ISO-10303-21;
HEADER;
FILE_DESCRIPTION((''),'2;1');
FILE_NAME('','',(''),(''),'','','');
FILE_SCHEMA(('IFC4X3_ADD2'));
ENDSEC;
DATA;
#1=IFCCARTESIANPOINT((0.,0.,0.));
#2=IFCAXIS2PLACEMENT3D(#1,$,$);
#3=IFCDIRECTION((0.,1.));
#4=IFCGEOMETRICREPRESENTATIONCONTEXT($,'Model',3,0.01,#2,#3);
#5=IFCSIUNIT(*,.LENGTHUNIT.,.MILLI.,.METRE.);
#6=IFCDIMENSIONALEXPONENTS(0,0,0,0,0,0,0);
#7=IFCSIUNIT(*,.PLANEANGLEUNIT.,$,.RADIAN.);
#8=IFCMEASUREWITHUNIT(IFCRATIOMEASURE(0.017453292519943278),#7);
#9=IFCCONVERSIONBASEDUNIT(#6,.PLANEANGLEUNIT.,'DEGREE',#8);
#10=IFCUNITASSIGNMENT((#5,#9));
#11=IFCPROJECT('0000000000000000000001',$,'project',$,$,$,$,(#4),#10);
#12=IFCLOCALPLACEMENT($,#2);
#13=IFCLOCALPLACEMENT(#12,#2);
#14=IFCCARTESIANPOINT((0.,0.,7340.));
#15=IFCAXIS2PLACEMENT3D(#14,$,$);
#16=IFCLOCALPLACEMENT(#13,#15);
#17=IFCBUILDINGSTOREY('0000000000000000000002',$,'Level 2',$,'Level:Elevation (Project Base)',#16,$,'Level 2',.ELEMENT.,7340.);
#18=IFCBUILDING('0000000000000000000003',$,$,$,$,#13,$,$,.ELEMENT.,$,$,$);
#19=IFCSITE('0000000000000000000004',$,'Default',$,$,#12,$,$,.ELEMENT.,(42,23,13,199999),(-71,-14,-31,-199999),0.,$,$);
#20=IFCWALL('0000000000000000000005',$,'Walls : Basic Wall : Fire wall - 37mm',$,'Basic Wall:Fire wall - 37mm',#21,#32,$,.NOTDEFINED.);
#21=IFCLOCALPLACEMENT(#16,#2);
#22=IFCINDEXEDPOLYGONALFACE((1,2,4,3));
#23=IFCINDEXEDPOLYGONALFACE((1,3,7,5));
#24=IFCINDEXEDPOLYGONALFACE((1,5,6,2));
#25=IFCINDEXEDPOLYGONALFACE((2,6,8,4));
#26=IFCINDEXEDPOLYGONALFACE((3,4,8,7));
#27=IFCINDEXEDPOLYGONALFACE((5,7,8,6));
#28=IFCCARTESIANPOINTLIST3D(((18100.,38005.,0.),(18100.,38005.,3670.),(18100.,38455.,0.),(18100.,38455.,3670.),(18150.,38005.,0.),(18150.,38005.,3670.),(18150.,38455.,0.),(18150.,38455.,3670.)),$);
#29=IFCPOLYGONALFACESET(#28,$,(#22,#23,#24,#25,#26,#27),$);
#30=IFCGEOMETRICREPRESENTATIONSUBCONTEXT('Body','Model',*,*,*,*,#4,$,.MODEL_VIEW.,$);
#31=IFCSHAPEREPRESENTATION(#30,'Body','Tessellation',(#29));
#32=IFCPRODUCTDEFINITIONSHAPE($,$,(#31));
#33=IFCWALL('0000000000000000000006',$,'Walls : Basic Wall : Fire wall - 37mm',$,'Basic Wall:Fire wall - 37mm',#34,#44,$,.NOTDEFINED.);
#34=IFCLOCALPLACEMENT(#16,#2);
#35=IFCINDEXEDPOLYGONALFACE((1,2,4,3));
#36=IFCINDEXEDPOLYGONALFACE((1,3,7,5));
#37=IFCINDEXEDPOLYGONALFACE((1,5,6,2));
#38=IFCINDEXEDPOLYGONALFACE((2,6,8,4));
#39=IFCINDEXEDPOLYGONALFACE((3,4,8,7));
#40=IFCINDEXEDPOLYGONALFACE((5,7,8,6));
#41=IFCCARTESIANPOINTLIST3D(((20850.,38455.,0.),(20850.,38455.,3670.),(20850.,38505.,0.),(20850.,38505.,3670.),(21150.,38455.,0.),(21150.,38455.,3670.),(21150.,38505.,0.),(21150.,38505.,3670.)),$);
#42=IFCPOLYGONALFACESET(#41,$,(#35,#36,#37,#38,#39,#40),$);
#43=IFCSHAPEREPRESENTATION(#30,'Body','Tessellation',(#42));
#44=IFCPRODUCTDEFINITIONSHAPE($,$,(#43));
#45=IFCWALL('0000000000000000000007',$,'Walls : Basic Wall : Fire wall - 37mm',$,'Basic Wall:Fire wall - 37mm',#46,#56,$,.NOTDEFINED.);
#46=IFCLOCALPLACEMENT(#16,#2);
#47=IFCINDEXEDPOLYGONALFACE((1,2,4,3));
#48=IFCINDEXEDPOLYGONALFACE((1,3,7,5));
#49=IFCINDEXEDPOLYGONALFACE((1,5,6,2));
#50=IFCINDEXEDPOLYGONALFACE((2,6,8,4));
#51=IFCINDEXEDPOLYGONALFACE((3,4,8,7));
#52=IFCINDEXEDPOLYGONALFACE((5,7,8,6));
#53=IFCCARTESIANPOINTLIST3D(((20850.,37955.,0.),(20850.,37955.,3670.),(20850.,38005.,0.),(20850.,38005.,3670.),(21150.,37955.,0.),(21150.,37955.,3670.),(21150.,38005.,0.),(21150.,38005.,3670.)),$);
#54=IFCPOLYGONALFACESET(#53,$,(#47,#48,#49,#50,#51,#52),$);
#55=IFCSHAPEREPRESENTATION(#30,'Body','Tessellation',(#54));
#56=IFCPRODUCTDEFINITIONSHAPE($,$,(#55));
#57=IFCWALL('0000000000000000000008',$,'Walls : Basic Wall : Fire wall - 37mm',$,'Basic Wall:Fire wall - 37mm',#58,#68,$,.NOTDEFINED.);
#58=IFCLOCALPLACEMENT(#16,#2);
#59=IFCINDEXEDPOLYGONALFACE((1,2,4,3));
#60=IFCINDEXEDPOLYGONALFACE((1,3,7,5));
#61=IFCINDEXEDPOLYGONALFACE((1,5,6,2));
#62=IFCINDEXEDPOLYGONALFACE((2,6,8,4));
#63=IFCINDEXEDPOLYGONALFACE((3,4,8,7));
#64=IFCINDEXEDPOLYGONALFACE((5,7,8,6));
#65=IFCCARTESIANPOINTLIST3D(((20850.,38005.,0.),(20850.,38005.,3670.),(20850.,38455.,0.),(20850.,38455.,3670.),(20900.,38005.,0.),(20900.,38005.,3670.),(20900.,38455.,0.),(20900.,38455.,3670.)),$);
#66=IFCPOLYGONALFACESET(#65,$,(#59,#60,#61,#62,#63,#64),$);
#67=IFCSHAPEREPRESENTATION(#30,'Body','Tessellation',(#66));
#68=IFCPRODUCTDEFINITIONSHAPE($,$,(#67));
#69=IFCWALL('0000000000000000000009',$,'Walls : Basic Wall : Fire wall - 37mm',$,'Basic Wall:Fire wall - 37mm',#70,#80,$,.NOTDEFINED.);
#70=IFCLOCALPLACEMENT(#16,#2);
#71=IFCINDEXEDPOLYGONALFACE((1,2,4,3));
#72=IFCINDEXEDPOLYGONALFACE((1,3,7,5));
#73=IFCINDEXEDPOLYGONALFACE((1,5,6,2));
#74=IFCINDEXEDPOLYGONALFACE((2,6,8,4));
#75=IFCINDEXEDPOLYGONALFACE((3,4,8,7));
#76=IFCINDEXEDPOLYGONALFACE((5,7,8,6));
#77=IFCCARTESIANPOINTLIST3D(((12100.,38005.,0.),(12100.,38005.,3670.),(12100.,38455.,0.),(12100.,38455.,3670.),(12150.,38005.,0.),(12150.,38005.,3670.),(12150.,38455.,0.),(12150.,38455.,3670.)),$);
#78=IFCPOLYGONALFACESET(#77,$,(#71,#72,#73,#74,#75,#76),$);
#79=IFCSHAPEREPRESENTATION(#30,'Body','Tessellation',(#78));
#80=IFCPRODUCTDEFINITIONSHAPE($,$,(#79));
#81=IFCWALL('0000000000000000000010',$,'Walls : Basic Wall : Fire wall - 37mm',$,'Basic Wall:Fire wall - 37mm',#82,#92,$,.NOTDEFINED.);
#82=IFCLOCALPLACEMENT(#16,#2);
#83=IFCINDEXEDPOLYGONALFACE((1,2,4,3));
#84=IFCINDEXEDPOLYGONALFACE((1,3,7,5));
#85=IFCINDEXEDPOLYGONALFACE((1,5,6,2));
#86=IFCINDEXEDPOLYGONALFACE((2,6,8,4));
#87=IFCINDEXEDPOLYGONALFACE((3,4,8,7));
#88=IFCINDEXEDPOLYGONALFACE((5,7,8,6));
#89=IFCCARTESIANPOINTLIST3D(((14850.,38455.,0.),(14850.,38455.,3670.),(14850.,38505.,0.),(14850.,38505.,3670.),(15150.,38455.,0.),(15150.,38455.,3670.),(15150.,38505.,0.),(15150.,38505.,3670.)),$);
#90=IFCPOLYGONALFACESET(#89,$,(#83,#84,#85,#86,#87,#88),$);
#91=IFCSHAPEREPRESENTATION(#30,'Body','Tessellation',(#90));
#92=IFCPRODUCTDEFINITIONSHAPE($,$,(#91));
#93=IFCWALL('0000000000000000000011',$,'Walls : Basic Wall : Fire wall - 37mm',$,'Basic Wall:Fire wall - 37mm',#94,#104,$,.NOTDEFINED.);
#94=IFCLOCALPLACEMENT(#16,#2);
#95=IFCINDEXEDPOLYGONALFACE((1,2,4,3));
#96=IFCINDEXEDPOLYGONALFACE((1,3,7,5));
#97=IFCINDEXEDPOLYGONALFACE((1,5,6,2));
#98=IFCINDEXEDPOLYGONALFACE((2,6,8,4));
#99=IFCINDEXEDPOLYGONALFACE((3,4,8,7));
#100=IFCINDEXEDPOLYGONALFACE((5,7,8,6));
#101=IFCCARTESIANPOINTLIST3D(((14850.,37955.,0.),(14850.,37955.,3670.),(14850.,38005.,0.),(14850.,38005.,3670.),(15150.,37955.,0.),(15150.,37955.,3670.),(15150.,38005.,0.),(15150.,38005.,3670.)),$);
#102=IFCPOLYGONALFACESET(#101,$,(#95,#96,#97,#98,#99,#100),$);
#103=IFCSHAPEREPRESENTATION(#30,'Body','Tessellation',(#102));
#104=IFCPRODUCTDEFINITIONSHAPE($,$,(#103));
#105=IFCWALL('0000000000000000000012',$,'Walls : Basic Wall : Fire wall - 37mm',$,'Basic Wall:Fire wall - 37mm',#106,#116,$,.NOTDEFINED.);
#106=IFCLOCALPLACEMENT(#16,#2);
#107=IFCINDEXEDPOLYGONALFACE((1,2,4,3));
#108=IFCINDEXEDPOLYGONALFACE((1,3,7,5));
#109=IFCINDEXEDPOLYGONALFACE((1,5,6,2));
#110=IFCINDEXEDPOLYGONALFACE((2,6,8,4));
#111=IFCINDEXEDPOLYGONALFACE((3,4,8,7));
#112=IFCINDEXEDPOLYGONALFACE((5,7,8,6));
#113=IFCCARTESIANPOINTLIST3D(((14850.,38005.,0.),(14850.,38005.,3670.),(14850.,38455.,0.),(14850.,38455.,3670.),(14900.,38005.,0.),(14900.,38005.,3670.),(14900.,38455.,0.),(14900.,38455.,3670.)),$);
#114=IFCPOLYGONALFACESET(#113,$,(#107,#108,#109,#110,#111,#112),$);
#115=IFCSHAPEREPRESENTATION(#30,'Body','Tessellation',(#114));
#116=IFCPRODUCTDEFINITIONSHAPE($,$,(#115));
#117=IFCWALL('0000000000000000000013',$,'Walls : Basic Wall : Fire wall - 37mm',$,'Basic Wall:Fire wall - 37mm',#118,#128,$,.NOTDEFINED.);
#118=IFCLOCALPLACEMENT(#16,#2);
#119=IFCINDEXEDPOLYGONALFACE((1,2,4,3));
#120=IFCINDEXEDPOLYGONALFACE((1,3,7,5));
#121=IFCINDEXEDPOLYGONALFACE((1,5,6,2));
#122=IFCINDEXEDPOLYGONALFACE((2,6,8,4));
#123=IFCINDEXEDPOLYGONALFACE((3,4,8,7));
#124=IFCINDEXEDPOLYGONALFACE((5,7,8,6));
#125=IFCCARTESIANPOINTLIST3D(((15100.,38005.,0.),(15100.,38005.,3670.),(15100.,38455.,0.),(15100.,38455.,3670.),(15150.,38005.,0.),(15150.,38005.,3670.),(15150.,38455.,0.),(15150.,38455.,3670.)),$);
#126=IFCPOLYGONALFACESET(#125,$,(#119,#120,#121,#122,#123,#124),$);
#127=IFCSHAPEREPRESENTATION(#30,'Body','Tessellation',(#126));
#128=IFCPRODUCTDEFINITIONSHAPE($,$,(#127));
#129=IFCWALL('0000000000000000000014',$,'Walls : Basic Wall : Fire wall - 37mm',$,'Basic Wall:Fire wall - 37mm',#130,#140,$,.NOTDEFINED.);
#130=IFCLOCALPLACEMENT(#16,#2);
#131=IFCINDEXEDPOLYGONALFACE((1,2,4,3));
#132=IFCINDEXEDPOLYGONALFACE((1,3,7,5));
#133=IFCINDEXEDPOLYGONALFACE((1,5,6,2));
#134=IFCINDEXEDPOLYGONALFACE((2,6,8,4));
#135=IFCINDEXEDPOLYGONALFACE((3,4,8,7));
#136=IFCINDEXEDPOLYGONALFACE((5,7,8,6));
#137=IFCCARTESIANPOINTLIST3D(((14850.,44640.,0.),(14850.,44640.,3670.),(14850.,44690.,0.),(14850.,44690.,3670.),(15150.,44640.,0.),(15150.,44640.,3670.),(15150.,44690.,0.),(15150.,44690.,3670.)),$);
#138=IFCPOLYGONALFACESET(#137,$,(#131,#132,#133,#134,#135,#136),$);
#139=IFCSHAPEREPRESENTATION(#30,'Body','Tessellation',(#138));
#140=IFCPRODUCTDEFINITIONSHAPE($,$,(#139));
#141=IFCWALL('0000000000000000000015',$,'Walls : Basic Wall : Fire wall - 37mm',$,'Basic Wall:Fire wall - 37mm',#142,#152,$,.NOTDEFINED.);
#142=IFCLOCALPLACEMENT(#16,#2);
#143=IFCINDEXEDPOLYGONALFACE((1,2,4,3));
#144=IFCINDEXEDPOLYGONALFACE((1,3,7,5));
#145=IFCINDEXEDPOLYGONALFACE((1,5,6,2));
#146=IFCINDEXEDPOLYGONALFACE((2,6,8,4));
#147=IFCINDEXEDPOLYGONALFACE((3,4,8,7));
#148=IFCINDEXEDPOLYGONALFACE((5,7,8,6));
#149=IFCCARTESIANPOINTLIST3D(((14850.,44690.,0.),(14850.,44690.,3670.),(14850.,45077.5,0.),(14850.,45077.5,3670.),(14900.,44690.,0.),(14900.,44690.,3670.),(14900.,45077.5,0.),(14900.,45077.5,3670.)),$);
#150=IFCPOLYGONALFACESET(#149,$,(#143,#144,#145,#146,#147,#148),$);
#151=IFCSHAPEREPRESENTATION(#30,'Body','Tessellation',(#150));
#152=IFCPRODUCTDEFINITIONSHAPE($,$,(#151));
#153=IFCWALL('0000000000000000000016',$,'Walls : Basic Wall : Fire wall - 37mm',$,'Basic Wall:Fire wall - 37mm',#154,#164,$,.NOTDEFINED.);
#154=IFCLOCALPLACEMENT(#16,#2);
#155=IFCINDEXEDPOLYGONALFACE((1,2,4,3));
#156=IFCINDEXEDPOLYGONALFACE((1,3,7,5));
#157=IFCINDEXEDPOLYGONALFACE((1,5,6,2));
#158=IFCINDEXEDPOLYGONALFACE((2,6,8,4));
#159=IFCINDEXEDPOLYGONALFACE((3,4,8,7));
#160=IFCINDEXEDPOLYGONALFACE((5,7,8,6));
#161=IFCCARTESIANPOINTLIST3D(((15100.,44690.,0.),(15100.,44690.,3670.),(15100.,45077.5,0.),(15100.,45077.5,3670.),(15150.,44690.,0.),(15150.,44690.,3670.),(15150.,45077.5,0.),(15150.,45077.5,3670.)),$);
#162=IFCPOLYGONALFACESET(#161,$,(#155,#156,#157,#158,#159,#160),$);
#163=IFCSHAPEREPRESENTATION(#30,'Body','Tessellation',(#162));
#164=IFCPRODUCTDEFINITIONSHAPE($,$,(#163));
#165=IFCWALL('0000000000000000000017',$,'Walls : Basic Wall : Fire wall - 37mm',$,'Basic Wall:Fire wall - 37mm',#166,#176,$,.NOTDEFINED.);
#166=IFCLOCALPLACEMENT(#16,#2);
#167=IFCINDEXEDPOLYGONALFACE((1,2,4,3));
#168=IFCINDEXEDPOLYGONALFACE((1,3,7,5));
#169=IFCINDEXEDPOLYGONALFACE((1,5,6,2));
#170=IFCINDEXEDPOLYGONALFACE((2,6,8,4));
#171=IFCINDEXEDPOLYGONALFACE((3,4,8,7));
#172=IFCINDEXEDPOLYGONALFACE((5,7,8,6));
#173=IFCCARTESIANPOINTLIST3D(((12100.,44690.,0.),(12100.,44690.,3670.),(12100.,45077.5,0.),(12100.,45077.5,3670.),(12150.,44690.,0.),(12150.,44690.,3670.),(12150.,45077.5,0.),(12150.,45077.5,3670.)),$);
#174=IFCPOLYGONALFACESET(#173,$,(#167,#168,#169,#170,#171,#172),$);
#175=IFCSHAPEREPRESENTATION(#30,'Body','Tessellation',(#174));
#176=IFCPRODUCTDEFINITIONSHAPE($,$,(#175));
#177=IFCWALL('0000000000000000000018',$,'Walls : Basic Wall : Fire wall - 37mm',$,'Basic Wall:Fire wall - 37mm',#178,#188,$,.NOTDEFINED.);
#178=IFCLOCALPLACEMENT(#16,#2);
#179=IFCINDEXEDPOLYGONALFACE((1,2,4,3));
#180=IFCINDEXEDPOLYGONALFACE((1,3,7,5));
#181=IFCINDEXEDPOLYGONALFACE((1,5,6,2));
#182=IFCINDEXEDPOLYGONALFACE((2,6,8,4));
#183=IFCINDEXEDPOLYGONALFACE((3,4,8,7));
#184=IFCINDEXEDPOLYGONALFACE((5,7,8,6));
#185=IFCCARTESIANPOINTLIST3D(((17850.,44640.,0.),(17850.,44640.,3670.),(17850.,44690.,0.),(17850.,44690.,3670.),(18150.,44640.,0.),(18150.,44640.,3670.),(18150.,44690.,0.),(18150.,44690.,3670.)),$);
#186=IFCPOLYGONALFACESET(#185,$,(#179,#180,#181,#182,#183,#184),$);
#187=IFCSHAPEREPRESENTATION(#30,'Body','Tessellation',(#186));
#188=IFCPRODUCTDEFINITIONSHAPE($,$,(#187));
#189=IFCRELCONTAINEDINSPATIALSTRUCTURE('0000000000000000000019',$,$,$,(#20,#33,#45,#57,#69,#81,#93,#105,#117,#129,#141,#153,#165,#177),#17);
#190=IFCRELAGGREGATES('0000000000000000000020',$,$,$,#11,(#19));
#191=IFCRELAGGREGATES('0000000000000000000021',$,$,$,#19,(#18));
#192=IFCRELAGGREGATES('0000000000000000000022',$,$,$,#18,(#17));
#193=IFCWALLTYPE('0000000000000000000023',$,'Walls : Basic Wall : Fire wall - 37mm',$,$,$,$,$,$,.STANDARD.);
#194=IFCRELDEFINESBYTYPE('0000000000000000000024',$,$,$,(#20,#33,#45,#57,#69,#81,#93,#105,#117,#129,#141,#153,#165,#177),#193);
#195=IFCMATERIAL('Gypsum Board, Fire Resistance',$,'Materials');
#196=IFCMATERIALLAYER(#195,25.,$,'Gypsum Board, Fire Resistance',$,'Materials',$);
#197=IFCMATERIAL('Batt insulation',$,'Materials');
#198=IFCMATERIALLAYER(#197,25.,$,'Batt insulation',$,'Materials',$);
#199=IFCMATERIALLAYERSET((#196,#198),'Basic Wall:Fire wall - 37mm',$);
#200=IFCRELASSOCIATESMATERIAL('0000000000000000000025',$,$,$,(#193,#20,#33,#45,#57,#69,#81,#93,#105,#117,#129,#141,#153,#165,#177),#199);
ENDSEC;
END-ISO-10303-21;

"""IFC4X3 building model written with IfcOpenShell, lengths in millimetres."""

from ifc_helpers import new_model, entity, si_unit, converted_unit, direction, frame, frame_2d, origin, place, context, subcontext, project, spatial, rectangle, extrude, material, layer, layer_set, type_object, element, save


model = new_model("IFC4X3")

# Units and contexts
model_context = context("Model", 3, precision=0.01, world=origin(), true_north=direction((0.0, 1.0)))
body_context = subcontext(model_context, "Body", "Model", "MODEL_VIEW")
ifc_project = project(units=[si_unit("LENGTHUNIT", "METRE", prefix="MILLI"), converted_unit("PLANEANGLEUNIT", "DEGREE", entity("IfcRatioMeasure", 0.017453292519943278), si_unit("PLANEANGLEUNIT", "RADIAN"), dimensions=[0, 0, 0, 0, 0, 0, 0])], contexts=[model_context])

# Site, building, storey
site_placement = place(None, origin())
site = spatial("IfcSite", under=ifc_project, at=site_placement, Name="Default", CompositionType="ELEMENT", RefLatitude=(42, 23, 13, 199999), RefLongitude=(-71, -14, -31, -199999), RefElevation=0.0)
building_placement = place(site_placement, origin())
building = spatial("IfcBuilding", under=site, at=building_placement, CompositionType="ELEMENT")
storey_placement = place(building_placement, frame((0.0, 0.0, 7340.0)))
storey = spatial("IfcBuildingStorey", under=building, at=storey_placement, Name="Level 2", ObjectType="Level:Elevation (Project Base)", LongName="Level 2", CompositionType="ELEMENT", Elevation=7340.0)

# Walls
ifc_material_1 = material(Name="Gypsum Board, Fire Resistance", Category="Materials")
ifc_layer_1 = layer(ifc_material_1, 25.0, Name="Gypsum Board, Fire Resistance", Category="Materials")
ifc_material_2 = material(Name="Batt insulation", Category="Materials")
ifc_layer_2 = layer(ifc_material_2, 25.0, Name="Batt insulation", Category="Materials")
ifc_layer_set = layer_set([ifc_layer_1, ifc_layer_2], Name="Basic Wall:Fire wall - 37mm")
wall_type = type_object("IfcWallType", Name="Walls : Basic Wall : Fire wall - 37mm", PredefinedType="STANDARD", material=ifc_layer_set)
for number, where, z_axis, x_axis, name in (
    (1, (18125.0, 38455.0, 0.0), (0.0, 0.0, 1.0), (0.0, -1.0, 0.0), "Walls : Basic Wall : Fire wall - 37mm"),
):
    element("IfcWall", number, at=place(storey_placement, frame(where, z_axis=z_axis, x_axis=x_axis)), inside=storey, type_object=wall_type, material=ifc_layer_set, Name=name, ObjectType="Basic Wall:Fire wall - 37mm", PredefinedType="NOTDEFINED", context=body_context, shape_type="SweptSolid", body=[
        extrude(rectangle(XDim=450.0, YDim=50.0, at=frame_2d((225.0, 0.0), x_axis=(-1.0, 0.0))), origin(), (0.0, 0.0, 1.0), 3670.0),
    ])
for number, where, name in (
    (2, (20850.0, 38480.0, 0.0), "Walls : Basic Wall : Fire wall - 37mm"),
    (3, (20850.0, 37980.0, 0.0), "Walls : Basic Wall : Fire wall - 37mm"),
):
    element("IfcWall", number, at=place(storey_placement, frame(where)), inside=storey, type_object=wall_type, material=ifc_layer_set, Name=name, ObjectType="Basic Wall:Fire wall - 37mm", PredefinedType="NOTDEFINED", context=body_context, shape_type="SweptSolid", body=[
        extrude(rectangle(XDim=300.0, YDim=50.0, at=frame_2d((150.0, 0.0), x_axis=(-1.0, 0.0))), origin(), (0.0, 0.0, 1.0), 3670.0),
    ])
wall_1_placement = place(storey_placement, frame((20875.0, 38455.0, 0.0), z_axis=(0.0, 0.0, 1.0), x_axis=(0.0, -1.0, 0.0)))
element("IfcWall", 4, at=wall_1_placement, inside=storey, type_object=wall_type, material=ifc_layer_set, Name="Walls : Basic Wall : Fire wall - 37mm", ObjectType="Basic Wall:Fire wall - 37mm", PredefinedType="NOTDEFINED", context=body_context, shape_type="SweptSolid", body=[
    extrude(rectangle(XDim=450.0, YDim=50.0, at=frame_2d((225.0, 0.0), x_axis=(-1.0, 0.0))), origin(), (0.0, 0.0, 1.0), 3670.0),
])
wall_2_placement = place(storey_placement, frame((12125.0, 38455.0, 0.0), z_axis=(0.0, 0.0, 1.0), x_axis=(0.0, -1.0, 0.0)))
element("IfcWall", 5, at=wall_2_placement, inside=storey, type_object=wall_type, material=ifc_layer_set, Name="Walls : Basic Wall : Fire wall - 37mm", ObjectType="Basic Wall:Fire wall - 37mm", PredefinedType="NOTDEFINED", context=body_context, shape_type="SweptSolid", body=[
    extrude(rectangle(XDim=450.0, YDim=50.0, at=frame_2d((225.0, 0.0), x_axis=(-1.0, 0.0))), origin(), (0.0, 0.0, 1.0), 3670.0),
])
for number, where, name in (
    (6, (14850.0, 38480.0, 0.0), "Walls : Basic Wall : Fire wall - 37mm"),
    (7, (14850.0, 37980.0, 0.0), "Walls : Basic Wall : Fire wall - 37mm"),
):
    element("IfcWall", number, at=place(storey_placement, frame(where)), inside=storey, type_object=wall_type, material=ifc_layer_set, Name=name, ObjectType="Basic Wall:Fire wall - 37mm", PredefinedType="NOTDEFINED", context=body_context, shape_type="SweptSolid", body=[
        extrude(rectangle(XDim=300.0, YDim=50.0, at=frame_2d((150.0, 0.0), x_axis=(-1.0, 0.0))), origin(), (0.0, 0.0, 1.0), 3670.0),
    ])
for number, where, z_axis, x_axis, name in (
    (8, (14875.0, 38455.0, 0.0), (0.0, 0.0, 1.0), (0.0, -1.0, 0.0), "Walls : Basic Wall : Fire wall - 37mm"),
    (9, (15125.0, 38455.0, 0.0), (0.0, 0.0, 1.0), (0.0, -1.0, 0.0), "Walls : Basic Wall : Fire wall - 37mm"),
):
    element("IfcWall", number, at=place(storey_placement, frame(where, z_axis=z_axis, x_axis=x_axis)), inside=storey, type_object=wall_type, material=ifc_layer_set, Name=name, ObjectType="Basic Wall:Fire wall - 37mm", PredefinedType="NOTDEFINED", context=body_context, shape_type="SweptSolid", body=[
        extrude(rectangle(XDim=450.0, YDim=50.0, at=frame_2d((225.0, 0.0), x_axis=(-1.0, 0.0))), origin(), (0.0, 0.0, 1.0), 3670.0),
    ])
wall_3_placement = place(storey_placement, frame((14850.0, 44665.0, 0.0)))
element("IfcWall", 10, at=wall_3_placement, inside=storey, type_object=wall_type, material=ifc_layer_set, Name="Walls : Basic Wall : Fire wall - 37mm", ObjectType="Basic Wall:Fire wall - 37mm", PredefinedType="NOTDEFINED", context=body_context, shape_type="SweptSolid", body=[
    extrude(rectangle(XDim=300.0, YDim=50.0, at=frame_2d((150.0, 0.0), x_axis=(-1.0, 0.0))), origin(), (0.0, 0.0, 1.0), 3670.0),
])
wall_4_placement = place(storey_placement, frame((14875.0, 45077.5, 0.0), z_axis=(0.0, 0.0, 1.0), x_axis=(0.0, -1.0, 0.0)))
element("IfcWall", 11, at=wall_4_placement, inside=storey, type_object=wall_type, material=ifc_layer_set, Name="Walls : Basic Wall : Fire wall - 37mm", ObjectType="Basic Wall:Fire wall - 37mm", PredefinedType="NOTDEFINED", context=body_context, shape_type="SweptSolid", body=[
    extrude(rectangle(XDim=387.5, YDim=50.0, at=frame_2d((193.8, 0.0), x_axis=(-1.0, 0.0))), origin(), (0.0, 0.0, 1.0), 3670.0),
])
wall_5_placement = place(storey_placement, frame((15125.0, 45077.5, 0.0), z_axis=(0.0, 0.0, 1.0), x_axis=(0.0, -1.0, 0.0)))
element("IfcWall", 12, at=wall_5_placement, inside=storey, type_object=wall_type, material=ifc_layer_set, Name="Walls : Basic Wall : Fire wall - 37mm", ObjectType="Basic Wall:Fire wall - 37mm", PredefinedType="NOTDEFINED", context=body_context, shape_type="SweptSolid", body=[
    extrude(rectangle(XDim=387.5, YDim=50.0, at=frame_2d((193.8, 0.0), x_axis=(-1.0, 0.0))), origin(), (0.0, 0.0, 1.0), 3670.0),
])
wall_6_placement = place(storey_placement, frame((12125.0, 45077.5, 0.0), z_axis=(0.0, 0.0, 1.0), x_axis=(0.0, -1.0, 0.0)))
element("IfcWall", 13, at=wall_6_placement, inside=storey, type_object=wall_type, material=ifc_layer_set, Name="Walls : Basic Wall : Fire wall - 37mm", ObjectType="Basic Wall:Fire wall - 37mm", PredefinedType="NOTDEFINED", context=body_context, shape_type="SweptSolid", body=[
    extrude(rectangle(XDim=387.5, YDim=50.0, at=frame_2d((193.8, 0.0), x_axis=(-1.0, 0.0))), origin(), (0.0, 0.0, 1.0), 3670.0),
])
wall_7_placement = place(storey_placement, frame((17850.0, 44665.0, 0.0)))
element("IfcWall", 14, at=wall_7_placement, inside=storey, type_object=wall_type, material=ifc_layer_set, Name="Walls : Basic Wall : Fire wall - 37mm", ObjectType="Basic Wall:Fire wall - 37mm", PredefinedType="NOTDEFINED", context=body_context, shape_type="SweptSolid", body=[
    extrude(rectangle(XDim=300.0, YDim=50.0, at=frame_2d((150.0, 0.0), x_axis=(-1.0, 0.0))), origin(), (0.0, 0.0, 1.0), 3670.0),
])

save(model, "model.ifc")
